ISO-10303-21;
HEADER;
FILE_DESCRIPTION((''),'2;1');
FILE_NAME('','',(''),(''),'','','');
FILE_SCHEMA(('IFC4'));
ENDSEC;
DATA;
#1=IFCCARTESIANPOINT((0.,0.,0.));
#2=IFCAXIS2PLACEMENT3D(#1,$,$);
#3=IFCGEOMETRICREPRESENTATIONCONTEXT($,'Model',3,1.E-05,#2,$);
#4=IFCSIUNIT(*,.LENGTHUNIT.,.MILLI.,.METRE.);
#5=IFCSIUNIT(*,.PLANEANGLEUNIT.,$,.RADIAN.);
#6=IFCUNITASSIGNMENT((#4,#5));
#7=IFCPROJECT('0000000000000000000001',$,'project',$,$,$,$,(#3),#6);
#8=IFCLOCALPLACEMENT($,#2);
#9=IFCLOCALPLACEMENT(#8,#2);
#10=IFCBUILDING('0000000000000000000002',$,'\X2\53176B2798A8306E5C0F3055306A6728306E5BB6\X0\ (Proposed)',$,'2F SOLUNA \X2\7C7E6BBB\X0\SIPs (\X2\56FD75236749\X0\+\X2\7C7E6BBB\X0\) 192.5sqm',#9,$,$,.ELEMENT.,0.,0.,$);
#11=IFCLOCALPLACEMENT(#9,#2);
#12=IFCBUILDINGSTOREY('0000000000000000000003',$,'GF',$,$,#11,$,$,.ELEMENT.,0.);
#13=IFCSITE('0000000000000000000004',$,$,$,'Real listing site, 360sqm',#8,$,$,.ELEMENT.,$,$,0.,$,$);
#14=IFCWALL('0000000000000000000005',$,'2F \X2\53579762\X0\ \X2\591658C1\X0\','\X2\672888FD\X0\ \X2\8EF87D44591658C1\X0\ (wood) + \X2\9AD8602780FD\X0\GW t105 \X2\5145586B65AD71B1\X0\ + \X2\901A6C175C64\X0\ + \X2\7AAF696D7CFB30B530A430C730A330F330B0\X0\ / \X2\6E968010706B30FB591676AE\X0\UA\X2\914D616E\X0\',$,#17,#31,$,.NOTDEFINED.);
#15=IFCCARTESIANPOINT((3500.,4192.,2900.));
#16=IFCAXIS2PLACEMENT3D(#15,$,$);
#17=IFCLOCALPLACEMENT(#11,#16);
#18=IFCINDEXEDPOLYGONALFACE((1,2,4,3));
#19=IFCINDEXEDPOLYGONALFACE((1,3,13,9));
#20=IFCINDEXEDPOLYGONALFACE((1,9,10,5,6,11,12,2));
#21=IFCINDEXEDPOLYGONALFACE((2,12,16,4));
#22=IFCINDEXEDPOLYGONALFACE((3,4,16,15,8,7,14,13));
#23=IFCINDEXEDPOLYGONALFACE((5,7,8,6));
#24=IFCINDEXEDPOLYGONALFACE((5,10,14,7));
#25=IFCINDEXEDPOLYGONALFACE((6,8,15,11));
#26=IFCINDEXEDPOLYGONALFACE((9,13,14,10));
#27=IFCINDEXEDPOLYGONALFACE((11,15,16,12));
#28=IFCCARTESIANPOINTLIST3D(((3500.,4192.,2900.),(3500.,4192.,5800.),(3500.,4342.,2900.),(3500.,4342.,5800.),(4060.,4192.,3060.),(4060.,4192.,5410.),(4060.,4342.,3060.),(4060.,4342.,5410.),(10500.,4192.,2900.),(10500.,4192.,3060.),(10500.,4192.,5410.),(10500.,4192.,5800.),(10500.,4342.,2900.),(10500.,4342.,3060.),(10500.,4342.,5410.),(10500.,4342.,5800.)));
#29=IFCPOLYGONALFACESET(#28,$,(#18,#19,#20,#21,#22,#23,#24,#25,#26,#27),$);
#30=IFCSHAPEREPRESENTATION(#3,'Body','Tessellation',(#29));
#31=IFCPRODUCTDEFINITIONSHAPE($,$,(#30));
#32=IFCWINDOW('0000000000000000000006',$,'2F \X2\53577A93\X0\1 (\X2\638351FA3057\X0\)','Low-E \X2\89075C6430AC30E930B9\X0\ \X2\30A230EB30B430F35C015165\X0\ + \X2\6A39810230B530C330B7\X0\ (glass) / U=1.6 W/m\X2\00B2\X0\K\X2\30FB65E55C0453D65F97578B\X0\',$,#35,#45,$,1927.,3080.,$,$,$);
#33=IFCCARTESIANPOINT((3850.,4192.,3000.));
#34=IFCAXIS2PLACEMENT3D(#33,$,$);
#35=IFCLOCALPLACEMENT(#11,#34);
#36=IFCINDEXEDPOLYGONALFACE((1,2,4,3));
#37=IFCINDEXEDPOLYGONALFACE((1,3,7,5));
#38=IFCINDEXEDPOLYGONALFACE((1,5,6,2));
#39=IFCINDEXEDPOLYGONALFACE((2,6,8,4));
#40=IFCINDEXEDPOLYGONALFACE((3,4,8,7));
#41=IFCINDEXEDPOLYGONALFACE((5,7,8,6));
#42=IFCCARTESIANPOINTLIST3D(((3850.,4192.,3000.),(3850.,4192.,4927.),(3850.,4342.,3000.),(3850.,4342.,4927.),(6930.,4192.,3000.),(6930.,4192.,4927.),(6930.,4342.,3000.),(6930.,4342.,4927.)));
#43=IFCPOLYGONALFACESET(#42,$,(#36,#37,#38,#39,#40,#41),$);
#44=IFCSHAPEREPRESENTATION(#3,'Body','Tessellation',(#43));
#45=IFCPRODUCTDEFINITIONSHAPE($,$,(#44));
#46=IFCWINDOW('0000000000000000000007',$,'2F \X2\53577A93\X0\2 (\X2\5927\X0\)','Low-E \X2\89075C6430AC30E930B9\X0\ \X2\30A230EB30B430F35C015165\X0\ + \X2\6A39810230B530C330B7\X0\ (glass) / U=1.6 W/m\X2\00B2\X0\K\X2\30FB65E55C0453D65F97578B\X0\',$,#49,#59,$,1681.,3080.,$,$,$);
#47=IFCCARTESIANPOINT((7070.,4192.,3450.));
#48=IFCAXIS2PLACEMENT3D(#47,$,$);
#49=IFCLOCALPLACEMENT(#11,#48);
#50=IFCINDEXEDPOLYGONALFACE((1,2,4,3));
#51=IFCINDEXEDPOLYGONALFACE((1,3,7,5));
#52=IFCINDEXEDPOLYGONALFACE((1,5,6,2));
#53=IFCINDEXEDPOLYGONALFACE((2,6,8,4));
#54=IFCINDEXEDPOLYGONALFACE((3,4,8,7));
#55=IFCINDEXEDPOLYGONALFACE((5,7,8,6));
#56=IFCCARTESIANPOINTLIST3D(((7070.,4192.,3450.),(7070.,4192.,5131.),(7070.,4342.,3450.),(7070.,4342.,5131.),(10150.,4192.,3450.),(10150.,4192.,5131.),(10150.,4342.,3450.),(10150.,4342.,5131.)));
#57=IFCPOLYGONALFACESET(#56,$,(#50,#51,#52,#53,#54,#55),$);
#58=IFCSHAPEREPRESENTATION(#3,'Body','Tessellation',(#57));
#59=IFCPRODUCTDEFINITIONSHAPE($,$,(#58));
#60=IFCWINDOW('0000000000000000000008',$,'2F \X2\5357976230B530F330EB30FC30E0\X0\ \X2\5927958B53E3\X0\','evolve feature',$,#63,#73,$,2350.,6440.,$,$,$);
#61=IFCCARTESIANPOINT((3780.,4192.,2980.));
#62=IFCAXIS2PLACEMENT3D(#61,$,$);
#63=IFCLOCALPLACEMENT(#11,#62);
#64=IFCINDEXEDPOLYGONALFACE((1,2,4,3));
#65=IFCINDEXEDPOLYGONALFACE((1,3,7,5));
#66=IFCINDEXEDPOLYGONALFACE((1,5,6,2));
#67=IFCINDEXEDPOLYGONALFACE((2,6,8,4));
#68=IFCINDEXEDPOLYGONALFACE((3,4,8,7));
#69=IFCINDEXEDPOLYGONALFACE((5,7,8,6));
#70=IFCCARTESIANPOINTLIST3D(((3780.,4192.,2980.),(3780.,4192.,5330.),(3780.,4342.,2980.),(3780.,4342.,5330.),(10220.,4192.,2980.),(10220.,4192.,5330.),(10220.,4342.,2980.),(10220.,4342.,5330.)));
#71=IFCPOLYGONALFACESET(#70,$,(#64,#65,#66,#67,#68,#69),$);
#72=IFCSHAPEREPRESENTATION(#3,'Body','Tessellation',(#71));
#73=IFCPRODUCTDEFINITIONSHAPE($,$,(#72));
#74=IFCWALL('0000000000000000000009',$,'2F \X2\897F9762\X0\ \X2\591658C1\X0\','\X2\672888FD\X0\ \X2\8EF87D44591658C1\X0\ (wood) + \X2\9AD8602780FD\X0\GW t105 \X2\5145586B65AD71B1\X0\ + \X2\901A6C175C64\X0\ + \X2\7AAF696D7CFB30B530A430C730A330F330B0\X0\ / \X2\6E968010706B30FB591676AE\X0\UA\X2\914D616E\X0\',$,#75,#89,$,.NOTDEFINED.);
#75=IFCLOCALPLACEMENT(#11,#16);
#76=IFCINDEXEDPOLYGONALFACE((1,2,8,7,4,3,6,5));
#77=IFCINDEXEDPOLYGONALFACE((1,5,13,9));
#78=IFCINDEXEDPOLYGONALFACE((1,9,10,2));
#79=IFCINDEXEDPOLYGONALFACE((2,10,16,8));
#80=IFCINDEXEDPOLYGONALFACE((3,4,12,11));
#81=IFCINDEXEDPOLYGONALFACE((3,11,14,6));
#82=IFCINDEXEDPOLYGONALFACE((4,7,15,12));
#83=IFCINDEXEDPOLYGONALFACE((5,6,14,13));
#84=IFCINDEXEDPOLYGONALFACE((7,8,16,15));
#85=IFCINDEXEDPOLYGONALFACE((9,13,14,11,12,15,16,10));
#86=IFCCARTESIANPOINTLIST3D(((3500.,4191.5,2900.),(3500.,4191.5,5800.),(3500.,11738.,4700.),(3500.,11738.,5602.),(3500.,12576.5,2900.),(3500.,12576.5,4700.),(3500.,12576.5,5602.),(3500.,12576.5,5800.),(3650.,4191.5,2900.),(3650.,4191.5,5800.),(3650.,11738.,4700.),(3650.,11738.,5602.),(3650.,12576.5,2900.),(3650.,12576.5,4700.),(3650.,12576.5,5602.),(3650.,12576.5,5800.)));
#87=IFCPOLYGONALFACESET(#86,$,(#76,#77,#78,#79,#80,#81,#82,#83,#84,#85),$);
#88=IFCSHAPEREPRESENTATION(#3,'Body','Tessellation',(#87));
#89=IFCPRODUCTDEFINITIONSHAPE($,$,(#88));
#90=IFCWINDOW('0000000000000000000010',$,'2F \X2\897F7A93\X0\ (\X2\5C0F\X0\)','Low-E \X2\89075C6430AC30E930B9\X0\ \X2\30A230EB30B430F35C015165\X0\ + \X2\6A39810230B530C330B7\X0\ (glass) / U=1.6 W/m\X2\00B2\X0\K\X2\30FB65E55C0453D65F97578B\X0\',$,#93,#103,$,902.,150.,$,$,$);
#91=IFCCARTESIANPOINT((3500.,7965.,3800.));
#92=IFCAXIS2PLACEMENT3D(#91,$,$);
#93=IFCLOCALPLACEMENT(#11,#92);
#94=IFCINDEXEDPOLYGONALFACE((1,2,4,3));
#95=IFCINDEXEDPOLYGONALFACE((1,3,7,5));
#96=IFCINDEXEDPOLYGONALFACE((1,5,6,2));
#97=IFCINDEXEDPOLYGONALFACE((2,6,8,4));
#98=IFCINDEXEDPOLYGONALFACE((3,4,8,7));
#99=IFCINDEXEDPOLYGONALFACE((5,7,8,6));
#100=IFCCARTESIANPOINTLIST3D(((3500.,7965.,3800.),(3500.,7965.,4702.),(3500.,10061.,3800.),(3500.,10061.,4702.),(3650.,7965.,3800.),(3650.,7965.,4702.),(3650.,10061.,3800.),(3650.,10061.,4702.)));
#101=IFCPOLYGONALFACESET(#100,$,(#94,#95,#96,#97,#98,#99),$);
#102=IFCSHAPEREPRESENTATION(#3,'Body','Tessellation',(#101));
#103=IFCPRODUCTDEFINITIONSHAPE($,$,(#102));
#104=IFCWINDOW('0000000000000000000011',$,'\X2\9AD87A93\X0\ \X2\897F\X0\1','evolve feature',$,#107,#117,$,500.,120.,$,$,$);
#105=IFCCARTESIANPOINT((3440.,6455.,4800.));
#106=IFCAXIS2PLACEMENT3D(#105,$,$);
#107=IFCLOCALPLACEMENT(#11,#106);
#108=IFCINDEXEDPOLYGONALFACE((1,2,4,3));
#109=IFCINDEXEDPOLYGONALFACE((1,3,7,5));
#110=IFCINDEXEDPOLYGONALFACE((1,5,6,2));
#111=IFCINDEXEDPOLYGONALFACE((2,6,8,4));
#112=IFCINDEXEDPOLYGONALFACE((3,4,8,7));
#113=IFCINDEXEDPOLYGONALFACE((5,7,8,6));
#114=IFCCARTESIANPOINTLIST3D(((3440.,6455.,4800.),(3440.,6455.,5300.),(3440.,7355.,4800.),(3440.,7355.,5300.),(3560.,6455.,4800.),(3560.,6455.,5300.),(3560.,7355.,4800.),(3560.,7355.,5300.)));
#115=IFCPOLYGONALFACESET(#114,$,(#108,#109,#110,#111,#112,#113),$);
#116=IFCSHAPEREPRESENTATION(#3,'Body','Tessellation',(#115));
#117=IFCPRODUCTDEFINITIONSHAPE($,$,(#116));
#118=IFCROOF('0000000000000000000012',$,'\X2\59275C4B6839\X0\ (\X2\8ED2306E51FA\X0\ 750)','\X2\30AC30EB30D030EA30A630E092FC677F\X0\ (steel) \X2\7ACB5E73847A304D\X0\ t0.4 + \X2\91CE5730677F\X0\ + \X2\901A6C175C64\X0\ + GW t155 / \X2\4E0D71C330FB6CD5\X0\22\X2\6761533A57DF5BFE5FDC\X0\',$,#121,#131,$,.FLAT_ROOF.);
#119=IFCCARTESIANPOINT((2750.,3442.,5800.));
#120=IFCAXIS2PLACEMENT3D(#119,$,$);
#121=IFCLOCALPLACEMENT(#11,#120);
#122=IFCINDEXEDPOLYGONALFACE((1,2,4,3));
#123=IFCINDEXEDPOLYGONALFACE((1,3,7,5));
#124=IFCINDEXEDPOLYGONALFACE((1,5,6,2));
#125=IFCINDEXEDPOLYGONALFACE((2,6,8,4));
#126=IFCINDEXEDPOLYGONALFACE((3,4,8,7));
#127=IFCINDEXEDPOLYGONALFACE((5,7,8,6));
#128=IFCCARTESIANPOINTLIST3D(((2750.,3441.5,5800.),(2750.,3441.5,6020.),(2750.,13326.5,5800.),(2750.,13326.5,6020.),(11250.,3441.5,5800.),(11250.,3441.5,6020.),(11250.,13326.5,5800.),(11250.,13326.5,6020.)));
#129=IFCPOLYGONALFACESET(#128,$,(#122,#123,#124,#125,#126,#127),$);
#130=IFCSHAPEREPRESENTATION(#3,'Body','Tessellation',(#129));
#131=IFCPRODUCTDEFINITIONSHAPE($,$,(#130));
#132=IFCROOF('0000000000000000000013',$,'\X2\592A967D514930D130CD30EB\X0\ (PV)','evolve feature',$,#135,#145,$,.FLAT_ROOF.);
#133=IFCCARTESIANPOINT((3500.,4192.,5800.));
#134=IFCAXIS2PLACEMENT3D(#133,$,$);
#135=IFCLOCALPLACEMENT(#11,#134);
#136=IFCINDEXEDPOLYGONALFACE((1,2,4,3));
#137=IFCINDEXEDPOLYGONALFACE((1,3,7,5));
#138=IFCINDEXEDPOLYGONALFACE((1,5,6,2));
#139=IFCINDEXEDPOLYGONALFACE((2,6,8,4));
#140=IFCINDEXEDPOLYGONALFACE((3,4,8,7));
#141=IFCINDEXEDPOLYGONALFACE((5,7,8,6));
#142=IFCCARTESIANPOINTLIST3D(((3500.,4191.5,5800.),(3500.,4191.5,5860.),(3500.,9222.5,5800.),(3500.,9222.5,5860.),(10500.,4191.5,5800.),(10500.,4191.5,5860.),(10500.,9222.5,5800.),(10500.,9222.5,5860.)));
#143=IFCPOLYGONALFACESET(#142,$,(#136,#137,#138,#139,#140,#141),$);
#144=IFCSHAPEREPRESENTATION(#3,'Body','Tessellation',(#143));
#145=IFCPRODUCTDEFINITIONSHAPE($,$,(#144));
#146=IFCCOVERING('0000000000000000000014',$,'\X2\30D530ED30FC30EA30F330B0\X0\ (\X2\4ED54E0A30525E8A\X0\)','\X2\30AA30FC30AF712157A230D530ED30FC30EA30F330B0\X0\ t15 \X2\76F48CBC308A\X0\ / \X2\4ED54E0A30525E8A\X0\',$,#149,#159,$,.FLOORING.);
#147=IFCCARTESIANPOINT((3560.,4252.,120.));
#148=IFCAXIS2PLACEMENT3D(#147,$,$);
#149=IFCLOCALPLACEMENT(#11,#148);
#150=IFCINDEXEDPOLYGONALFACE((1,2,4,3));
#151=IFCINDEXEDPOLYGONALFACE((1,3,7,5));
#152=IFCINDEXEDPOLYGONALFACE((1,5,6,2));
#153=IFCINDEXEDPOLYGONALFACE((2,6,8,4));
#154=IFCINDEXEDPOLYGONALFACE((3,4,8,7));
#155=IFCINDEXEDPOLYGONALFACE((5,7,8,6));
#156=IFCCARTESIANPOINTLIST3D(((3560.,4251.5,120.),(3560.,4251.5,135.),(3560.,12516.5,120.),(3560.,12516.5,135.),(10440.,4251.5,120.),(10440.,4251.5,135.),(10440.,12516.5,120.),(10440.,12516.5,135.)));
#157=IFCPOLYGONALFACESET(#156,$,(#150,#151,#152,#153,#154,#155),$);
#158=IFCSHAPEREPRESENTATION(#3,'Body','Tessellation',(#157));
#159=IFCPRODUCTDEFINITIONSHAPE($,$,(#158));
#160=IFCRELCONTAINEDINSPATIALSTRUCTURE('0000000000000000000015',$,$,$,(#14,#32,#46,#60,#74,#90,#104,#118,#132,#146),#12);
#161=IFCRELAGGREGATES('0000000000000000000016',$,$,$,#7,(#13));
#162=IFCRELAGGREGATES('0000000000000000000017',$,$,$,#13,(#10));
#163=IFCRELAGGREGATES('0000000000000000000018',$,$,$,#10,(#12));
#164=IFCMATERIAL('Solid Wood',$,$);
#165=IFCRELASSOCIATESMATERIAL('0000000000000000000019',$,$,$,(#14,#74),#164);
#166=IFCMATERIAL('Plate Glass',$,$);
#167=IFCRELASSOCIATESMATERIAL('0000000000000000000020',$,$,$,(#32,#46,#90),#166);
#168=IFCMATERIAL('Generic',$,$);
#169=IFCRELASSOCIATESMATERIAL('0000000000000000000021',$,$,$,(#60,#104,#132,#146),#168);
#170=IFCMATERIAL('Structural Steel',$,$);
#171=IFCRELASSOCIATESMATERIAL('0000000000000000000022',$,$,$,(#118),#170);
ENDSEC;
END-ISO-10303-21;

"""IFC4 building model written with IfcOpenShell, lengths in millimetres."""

from ifc_helpers import new_model, si_unit, frame, frame_2d, origin, place, context, project, spatial, rectangle, extrude, material, element, fill, save


model = new_model("IFC4")

# Units and contexts
model_context = context("Model", 3, precision=1e-05, world=origin())
ifc_project = project(units=[si_unit("LENGTHUNIT", "METRE", prefix="MILLI"), si_unit("PLANEANGLEUNIT", "RADIAN")], contexts=[model_context])

# Site, building, storey
site_placement = place(None, origin())
site = spatial("IfcSite", under=ifc_project, at=site_placement, ObjectType="Real listing site, 360sqm", CompositionType="ELEMENT", RefElevation=0.0)
building_placement = place(site_placement, origin())
building = spatial("IfcBuilding", under=site, at=building_placement, Name="北欧風の小さな木の家 (Proposed)", ObjectType="2F SOLUNA 籾殻SIPs (国産杉+籾殻) 192.5sqm", CompositionType="ELEMENT", ElevationOfRefHeight=0.0, ElevationOfTerrain=0.0)
storey_placement = place(building_placement, origin())
storey = spatial("IfcBuildingStorey", under=building, at=storey_placement, Name="GF", CompositionType="ELEMENT", Elevation=0.0)

# Shared definitions
ifc_material_1 = material(Name="Solid Wood")

# Shared definitions
ifc_material_2 = material(Name="Plate Glass")
ifc_material_3 = material(Name="Generic")

# Walls, openings, windows
wall_1_placement = place(storey_placement, frame((3500.0, 4192.0, 2900.0)))
wall_1 = element("IfcWall", 1, at=wall_1_placement, inside=storey, material=ifc_material_1, Name="2F 南面 外壁", Description="木製 軸組外壁 (wood) + 高性能GW t105 充填断熱 + 通気層 + 窯業系サイディング / 準耐火・外皮UA配慮", PredefinedType="NOTDEFINED", context=model_context, shape_type="SweptSolid", body=[
    extrude(rectangle(XDim=7000.0, YDim=150.0, at=frame_2d((3500.0, 75.0))), frame((3500.0, 4192.0, 2900.0)), (0.0, 0.0, 1.0), 2900.0),
])
opening_1_placement = place(storey_placement, frame((3850.0, 4192.0, 3000.0)))
opening_1 = element("IfcOpeningElement", 2, at=opening_1_placement, cuts=wall_1, PredefinedType="NOTDEFINED", context=model_context, shape_type="SweptSolid", body=[
    extrude(rectangle(XDim=3080.0, YDim=150.0, at=frame_2d((1540.0, 75.0))), frame((3850.0, 4192.0, 3000.0)), (0.0, 0.0, 1.0), 1927.0),
])
opening_2_placement = place(storey_placement, frame((7070.0, 4192.0, 3450.0)))
opening_2 = element("IfcOpeningElement", 3, at=opening_2_placement, cuts=wall_1, PredefinedType="NOTDEFINED", context=model_context, shape_type="SweptSolid", body=[
    extrude(rectangle(XDim=3080.0, YDim=150.0, at=frame_2d((1540.0, 75.0))), frame((7070.0, 4192.0, 3450.0)), (0.0, 0.0, 1.0), 1681.0),
])
opening_3_placement = place(storey_placement, frame((3780.0, 4192.0, 2980.0)))
opening_3 = element("IfcOpeningElement", 4, at=opening_3_placement, cuts=wall_1, PredefinedType="NOTDEFINED", context=model_context, shape_type="SweptSolid", body=[
    extrude(rectangle(XDim=6440.0, YDim=150.0, at=frame_2d((3220.0, 75.0))), frame((3780.0, 4192.0, 2980.0)), (0.0, 0.0, 1.0), 2350.0),
])
window_1_placement = place(storey_placement, frame((3850.0, 4192.0, 3000.0)))
window_1 = element("IfcWindow", 5, at=window_1_placement, inside=storey, material=ifc_material_2, Name="2F 南窓1 (掃出し)", Description="Low-E 複層ガラス アルゴン封入 + 樹脂サッシ (glass) / U=1.6 W/m²K・日射取得型", OverallHeight=1927.0, OverallWidth=3080.0, context=model_context, shape_type="SweptSolid", body=[
    extrude(rectangle(XDim=3080.0, YDim=150.0, at=frame_2d((1540.0, 75.0))), frame((3850.0, 4192.0, 3000.0)), (0.0, 0.0, 1.0), 1927.0),
])
fill(opening_1, window_1)
window_2_placement = place(storey_placement, frame((7070.0, 4192.0, 3450.0)))
window_2 = element("IfcWindow", 6, at=window_2_placement, inside=storey, material=ifc_material_2, Name="2F 南窓2 (大)", Description="Low-E 複層ガラス アルゴン封入 + 樹脂サッシ (glass) / U=1.6 W/m²K・日射取得型", OverallHeight=1681.0, OverallWidth=3080.0, context=model_context, shape_type="SweptSolid", body=[
    extrude(rectangle(XDim=3080.0, YDim=150.0, at=frame_2d((1540.0, 75.0))), frame((7070.0, 4192.0, 3450.0)), (0.0, 0.0, 1.0), 1681.0),
])
fill(opening_2, window_2)
window_3_placement = place(storey_placement, frame((3780.0, 4192.0, 2980.0)))
window_3 = element("IfcWindow", 7, at=window_3_placement, inside=storey, material=ifc_material_3, Name="2F 南面サンルーム 大開口", Description="evolve feature", OverallHeight=2350.0, OverallWidth=6440.0, context=model_context, shape_type="SweptSolid", body=[
    extrude(rectangle(XDim=6440.0, YDim=150.0, at=frame_2d((3220.0, 75.0))), frame((3780.0, 4192.0, 2980.0)), (0.0, 0.0, 1.0), 2350.0),
])
fill(opening_3, window_3)
wall_2_placement = place(storey_placement, frame((3500.0, 4192.0, 2900.0)))
wall_2 = element("IfcWall", 8, at=wall_2_placement, inside=storey, material=ifc_material_1, Name="2F 西面 外壁", Description="木製 軸組外壁 (wood) + 高性能GW t105 充填断熱 + 通気層 + 窯業系サイディング / 準耐火・外皮UA配慮", PredefinedType="NOTDEFINED", context=model_context, shape_type="SweptSolid", body=[
    extrude(rectangle(XDim=150.0, YDim=8385.0, at=frame_2d((75.0, 4192.0))), frame((3500.0, 4192.0, 2900.0)), (0.0, 0.0, 1.0), 2900.0),
])
opening_4_placement = place(storey_placement, frame((3500.0, 7965.0, 3800.0)))
opening_4 = element("IfcOpeningElement", 9, at=opening_4_placement, cuts=wall_2, PredefinedType="NOTDEFINED", context=model_context, shape_type="SweptSolid", body=[
    extrude(rectangle(XDim=150.0, YDim=2096.0, at=frame_2d((75.0, 1048.0))), frame((3500.0, 7965.0, 3800.0)), (0.0, 0.0, 1.0), 902.0),
])
opening_5_placement = place(storey_placement, frame((3440.0, 6455.0, 4800.0)))
opening_5 = element("IfcOpeningElement", 10, at=opening_5_placement, cuts=wall_2, PredefinedType="NOTDEFINED", context=model_context, shape_type="SweptSolid", body=[
    extrude(rectangle(XDim=120.0, YDim=900.0, at=frame_2d((60.0, 450.0))), frame((3440.0, 6455.0, 4800.0)), (0.0, 0.0, 1.0), 500.0),
])
window_4_placement = place(storey_placement, frame((3500.0, 7965.0, 3800.0)))
window_4 = element("IfcWindow", 11, at=window_4_placement, inside=storey, material=ifc_material_2, Name="2F 西窓 (小)", Description="Low-E 複層ガラス アルゴン封入 + 樹脂サッシ (glass) / U=1.6 W/m²K・日射取得型", OverallHeight=902.0, OverallWidth=150.0, context=model_context, shape_type="SweptSolid", body=[
    extrude(rectangle(XDim=150.0, YDim=2096.0, at=frame_2d((75.0, 1048.0))), frame((3500.0, 7965.0, 3800.0)), (0.0, 0.0, 1.0), 902.0),
])
fill(opening_4, window_4)
window_5_placement = place(storey_placement, frame((3440.0, 6455.0, 4800.0)))
window_5 = element("IfcWindow", 12, at=window_5_placement, inside=storey, material=ifc_material_3, Name="高窓 西1", Description="evolve feature", OverallHeight=500.0, OverallWidth=120.0, context=model_context, shape_type="SweptSolid", body=[
    extrude(rectangle(XDim=120.0, YDim=900.0, at=frame_2d((60.0, 450.0))), frame((3440.0, 6455.0, 4800.0)), (0.0, 0.0, 1.0), 500.0),
])
fill(opening_5, window_5)

# Roofs
ifc_material_4 = material(Name="Structural Steel")
roof_1_placement = place(storey_placement, frame((2750.0, 3442.0, 5800.0)))
element("IfcRoof", 13, at=roof_1_placement, inside=storey, material=ifc_material_4, Name="大屋根 (軒の出 750)", Description="ガルバリウム鋼板 (steel) 立平葺き t0.4 + 野地板 + 通気層 + GW t155 / 不燃・法22条区域対応", PredefinedType="FLAT_ROOF", context=model_context, shape_type="SweptSolid", body=[
    extrude(rectangle(XDim=8500.0, YDim=9885.0, at=frame_2d((4250.0, 4942.0))), frame((2750.0, 3442.0, 5800.0)), (0.0, 0.0, 1.0), 220.0),
])
roof_2_placement = place(storey_placement, frame((3500.0, 4192.0, 5800.0)))
element("IfcRoof", 14, at=roof_2_placement, inside=storey, material=ifc_material_3, Name="太陽光パネル (PV)", Description="evolve feature", PredefinedType="FLAT_ROOF", context=model_context, shape_type="SweptSolid", body=[
    extrude(rectangle(XDim=7000.0, YDim=5031.0, at=frame_2d((3500.0, 2515.0))), frame((3500.0, 4192.0, 5800.0)), (0.0, 0.0, 1.0), 60.0),
])

# Covering
covering_placement = place(storey_placement, frame((3560.0, 4252.0, 120.0)))
element("IfcCovering", 15, at=covering_placement, inside=storey, material=ifc_material_3, Name="フローリング (仕上げ床)", Description="オーク無垢フローリング t15 直貼り / 仕上げ床", PredefinedType="FLOORING", context=model_context, shape_type="SweptSolid", body=[
    extrude(rectangle(XDim=6880.0, YDim=8265.0, at=frame_2d((3440.0, 4132.0))), frame((3560.0, 4252.0, 120.0)), (0.0, 0.0, 1.0), 15.0),
])

save(model, "model.ifc")
